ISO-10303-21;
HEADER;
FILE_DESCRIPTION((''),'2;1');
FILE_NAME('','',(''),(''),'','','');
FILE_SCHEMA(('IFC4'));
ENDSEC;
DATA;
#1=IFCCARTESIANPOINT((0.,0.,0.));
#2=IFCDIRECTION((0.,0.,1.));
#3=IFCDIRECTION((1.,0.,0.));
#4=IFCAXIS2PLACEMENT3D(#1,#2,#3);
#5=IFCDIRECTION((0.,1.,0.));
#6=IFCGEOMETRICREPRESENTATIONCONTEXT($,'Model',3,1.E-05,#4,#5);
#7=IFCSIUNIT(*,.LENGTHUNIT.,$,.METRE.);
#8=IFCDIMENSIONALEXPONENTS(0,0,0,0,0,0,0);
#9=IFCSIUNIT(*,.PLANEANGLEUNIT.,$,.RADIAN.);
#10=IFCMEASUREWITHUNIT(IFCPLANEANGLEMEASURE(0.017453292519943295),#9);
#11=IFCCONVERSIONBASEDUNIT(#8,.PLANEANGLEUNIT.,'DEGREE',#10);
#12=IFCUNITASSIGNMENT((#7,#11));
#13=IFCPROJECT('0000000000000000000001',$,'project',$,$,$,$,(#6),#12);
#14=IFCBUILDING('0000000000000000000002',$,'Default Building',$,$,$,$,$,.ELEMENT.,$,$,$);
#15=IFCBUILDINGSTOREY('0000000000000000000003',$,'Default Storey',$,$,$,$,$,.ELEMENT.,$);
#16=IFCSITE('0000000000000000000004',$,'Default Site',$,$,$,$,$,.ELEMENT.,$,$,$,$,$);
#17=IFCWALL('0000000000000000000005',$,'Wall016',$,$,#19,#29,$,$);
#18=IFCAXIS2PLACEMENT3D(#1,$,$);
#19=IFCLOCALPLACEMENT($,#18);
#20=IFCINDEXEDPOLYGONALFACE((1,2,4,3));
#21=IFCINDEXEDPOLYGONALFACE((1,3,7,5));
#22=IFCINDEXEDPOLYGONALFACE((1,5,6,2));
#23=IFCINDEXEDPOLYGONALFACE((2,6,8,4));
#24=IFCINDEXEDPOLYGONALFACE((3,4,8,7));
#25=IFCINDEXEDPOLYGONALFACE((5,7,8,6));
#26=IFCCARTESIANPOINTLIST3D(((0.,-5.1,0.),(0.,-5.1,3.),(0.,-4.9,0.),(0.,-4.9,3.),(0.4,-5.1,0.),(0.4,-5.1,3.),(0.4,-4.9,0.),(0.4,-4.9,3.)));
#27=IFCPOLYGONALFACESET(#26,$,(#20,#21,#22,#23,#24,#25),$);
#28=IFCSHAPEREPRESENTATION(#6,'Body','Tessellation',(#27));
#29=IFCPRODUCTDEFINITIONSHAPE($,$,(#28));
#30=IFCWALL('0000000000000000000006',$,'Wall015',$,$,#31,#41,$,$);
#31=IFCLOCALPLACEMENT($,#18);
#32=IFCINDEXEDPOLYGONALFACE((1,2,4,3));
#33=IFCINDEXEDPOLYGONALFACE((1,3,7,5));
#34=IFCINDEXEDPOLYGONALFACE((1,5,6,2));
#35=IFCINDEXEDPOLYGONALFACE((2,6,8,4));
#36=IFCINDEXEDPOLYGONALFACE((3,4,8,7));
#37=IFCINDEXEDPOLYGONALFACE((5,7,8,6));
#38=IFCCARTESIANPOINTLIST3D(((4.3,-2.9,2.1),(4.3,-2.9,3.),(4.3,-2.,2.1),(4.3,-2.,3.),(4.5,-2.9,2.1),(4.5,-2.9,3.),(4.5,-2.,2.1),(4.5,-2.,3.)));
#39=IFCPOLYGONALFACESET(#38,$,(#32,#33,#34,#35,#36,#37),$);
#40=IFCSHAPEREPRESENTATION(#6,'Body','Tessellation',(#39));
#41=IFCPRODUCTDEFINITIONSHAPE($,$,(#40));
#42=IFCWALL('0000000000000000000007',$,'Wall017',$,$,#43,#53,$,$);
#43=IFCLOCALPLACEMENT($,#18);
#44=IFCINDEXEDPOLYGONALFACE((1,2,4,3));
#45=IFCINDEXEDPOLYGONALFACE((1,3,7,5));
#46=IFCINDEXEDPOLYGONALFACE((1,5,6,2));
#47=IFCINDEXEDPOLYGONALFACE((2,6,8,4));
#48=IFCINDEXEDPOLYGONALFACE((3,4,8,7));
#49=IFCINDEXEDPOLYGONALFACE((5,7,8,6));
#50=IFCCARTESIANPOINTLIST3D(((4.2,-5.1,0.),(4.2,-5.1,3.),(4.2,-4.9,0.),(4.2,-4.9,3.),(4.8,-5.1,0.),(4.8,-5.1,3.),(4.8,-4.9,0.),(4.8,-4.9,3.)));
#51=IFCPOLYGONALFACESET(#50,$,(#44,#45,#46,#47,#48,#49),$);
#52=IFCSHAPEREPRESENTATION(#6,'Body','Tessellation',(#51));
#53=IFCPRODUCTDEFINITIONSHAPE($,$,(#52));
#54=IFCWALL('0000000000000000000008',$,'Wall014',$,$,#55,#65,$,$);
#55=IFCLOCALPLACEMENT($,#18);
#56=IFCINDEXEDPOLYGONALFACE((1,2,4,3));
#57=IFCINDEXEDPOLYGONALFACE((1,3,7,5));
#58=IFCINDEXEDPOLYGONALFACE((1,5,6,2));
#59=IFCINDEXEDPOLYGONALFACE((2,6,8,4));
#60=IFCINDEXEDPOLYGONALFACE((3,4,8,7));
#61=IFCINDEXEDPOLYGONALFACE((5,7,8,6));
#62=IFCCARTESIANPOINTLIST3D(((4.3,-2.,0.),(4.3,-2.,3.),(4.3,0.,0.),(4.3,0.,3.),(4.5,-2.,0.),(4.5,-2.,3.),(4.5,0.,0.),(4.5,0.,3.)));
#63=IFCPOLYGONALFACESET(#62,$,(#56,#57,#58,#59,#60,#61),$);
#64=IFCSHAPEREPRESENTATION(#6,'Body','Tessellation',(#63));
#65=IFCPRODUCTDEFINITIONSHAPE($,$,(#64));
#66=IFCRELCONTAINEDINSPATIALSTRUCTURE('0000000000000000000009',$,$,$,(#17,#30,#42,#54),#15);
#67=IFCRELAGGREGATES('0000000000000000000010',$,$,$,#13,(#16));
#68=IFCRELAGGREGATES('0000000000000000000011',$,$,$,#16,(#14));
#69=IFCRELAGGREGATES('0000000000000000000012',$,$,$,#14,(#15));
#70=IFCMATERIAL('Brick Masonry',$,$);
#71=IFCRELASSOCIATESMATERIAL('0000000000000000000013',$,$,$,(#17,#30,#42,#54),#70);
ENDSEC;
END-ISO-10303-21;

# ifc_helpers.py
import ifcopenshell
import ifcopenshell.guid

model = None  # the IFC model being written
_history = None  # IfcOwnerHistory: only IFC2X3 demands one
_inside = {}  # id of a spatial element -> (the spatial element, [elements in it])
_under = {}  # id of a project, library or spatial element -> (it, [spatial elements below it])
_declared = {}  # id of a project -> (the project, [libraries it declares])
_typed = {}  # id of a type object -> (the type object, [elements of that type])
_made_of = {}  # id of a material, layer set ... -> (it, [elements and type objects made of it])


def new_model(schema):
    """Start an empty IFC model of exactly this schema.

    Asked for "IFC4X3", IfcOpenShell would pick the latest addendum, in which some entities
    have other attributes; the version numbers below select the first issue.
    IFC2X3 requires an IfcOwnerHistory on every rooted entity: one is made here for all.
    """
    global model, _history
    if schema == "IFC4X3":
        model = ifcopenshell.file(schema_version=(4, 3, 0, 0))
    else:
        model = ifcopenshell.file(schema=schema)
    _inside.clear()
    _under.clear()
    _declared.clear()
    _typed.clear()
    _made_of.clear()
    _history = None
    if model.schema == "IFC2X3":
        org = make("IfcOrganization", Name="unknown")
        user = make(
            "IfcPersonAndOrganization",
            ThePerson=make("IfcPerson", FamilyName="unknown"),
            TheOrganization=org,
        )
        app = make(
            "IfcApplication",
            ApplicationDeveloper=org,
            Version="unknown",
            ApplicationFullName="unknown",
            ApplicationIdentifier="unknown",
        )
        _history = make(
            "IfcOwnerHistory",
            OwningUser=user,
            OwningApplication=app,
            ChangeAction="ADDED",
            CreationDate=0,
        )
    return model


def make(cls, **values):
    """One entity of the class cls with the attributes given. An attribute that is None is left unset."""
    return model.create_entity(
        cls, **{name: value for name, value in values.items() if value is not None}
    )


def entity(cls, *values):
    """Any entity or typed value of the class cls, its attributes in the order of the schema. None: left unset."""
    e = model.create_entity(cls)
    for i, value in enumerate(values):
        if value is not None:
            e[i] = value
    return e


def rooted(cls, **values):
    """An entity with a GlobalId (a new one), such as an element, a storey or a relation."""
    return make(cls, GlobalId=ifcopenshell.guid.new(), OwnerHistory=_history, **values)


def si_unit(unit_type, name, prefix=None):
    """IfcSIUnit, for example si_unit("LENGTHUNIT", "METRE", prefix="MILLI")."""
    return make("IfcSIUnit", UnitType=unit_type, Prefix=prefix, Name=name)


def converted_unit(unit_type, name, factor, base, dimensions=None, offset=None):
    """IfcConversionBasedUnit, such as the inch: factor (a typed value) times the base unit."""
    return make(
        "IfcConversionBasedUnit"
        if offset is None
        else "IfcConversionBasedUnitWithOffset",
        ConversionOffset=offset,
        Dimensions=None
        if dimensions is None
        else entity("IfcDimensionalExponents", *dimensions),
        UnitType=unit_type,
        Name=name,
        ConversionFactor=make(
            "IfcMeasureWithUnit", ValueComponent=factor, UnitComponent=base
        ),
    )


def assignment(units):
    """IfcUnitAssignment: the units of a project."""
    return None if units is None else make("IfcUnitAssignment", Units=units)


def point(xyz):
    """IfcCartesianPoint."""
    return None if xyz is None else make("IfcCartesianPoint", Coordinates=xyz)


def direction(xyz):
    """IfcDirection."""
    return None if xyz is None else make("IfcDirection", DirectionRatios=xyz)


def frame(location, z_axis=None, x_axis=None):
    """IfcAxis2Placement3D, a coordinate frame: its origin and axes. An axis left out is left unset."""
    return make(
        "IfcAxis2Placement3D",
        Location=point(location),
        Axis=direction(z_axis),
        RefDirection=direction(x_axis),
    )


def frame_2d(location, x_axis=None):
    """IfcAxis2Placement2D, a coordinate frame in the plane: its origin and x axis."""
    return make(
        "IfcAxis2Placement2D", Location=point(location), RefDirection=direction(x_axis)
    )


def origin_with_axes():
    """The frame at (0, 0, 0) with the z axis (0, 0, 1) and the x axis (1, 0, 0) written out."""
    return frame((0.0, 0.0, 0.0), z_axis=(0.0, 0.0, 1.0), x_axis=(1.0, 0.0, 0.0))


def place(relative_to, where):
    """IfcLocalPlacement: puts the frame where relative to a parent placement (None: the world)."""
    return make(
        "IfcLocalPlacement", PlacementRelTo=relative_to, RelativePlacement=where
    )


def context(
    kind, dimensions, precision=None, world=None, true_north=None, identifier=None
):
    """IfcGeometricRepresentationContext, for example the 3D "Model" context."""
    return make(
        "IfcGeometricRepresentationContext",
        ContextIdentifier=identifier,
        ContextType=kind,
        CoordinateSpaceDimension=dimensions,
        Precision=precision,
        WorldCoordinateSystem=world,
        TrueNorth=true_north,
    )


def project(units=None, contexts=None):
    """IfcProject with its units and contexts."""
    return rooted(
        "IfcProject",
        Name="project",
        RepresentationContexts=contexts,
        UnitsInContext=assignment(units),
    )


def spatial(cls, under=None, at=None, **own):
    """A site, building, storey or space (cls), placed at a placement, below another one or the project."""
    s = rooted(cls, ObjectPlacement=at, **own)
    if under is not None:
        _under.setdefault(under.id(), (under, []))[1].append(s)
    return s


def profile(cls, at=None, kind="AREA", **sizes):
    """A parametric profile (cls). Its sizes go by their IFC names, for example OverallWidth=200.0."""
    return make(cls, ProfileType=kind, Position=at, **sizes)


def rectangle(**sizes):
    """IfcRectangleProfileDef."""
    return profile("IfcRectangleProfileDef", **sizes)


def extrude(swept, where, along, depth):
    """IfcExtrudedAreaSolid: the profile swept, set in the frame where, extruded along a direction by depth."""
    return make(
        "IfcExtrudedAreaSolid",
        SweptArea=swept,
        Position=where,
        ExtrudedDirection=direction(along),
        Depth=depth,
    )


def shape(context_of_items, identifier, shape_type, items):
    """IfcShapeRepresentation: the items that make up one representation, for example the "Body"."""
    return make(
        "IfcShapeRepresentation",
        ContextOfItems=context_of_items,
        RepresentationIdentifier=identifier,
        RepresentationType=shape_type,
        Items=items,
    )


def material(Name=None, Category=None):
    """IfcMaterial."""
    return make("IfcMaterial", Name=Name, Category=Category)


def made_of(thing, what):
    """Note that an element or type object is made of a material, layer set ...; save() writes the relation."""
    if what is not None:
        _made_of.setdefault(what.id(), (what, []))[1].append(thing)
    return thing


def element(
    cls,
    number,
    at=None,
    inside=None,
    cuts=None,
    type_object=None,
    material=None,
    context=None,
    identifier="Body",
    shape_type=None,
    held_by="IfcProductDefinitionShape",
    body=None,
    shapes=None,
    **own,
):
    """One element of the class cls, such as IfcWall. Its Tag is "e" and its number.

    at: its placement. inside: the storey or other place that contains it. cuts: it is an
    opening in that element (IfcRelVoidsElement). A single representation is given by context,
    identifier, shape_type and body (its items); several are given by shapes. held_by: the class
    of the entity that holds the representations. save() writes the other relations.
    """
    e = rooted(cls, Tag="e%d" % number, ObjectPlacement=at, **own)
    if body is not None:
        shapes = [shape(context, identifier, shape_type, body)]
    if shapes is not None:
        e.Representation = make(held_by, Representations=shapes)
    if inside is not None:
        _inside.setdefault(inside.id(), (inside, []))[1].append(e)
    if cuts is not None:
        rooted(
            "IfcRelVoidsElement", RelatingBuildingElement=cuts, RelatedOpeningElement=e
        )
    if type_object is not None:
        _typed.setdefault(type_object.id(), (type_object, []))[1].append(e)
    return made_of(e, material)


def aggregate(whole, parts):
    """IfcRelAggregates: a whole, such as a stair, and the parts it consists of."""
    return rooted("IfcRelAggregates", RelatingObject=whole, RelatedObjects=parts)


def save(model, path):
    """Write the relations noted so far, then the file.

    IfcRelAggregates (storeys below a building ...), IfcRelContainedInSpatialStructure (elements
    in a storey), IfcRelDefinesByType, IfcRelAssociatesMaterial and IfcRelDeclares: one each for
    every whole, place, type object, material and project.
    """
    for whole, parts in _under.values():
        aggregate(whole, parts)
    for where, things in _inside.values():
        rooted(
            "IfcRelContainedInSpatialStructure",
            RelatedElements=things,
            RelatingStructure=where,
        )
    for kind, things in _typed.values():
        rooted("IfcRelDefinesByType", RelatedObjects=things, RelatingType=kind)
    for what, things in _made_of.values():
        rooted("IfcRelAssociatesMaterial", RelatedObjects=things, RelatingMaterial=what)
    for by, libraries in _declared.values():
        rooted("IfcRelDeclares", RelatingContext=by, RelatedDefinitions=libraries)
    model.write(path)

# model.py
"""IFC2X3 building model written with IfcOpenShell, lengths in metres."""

from ifc_helpers import new_model, entity, si_unit, converted_unit, direction, frame, frame_2d, origin_with_axes, place, context, project, spatial, rectangle, extrude, material, element, save


model = new_model("IFC2X3")

# Units and contexts
model_context = context("Model", 3, precision=1e-05, world=origin_with_axes(), true_north=direction((0.0, 1.0, 0.0)))
ifc_project = project(units=[si_unit("LENGTHUNIT", "METRE"), converted_unit("PLANEANGLEUNIT", "DEGREE", entity("IfcPlaneAngleMeasure", 0.017453292519943295), si_unit("PLANEANGLEUNIT", "RADIAN"), dimensions=[0, 0, 0, 0, 0, 0, 0])], contexts=[model_context])

# Site, building, storey
site = spatial("IfcSite", under=ifc_project, Name="Default Site", CompositionType="ELEMENT")
building = spatial("IfcBuilding", under=site, Name="Default Building", CompositionType="ELEMENT")
storey = spatial("IfcBuildingStorey", under=building, Name="Default Storey", CompositionType="ELEMENT")

# Shared definitions
placement = place(None, origin_with_axes())

# Walls
ifc_material_1 = material(Name="Brick Masonry")
element("IfcWall", 1, at=placement, inside=storey, material=ifc_material_1, Name="Wall016", context=model_context, shape_type="SweptSolid", body=[
    extrude(rectangle(XDim=0.4, YDim=0.2, at=frame_2d((0.0, 0.0), x_axis=(1.0, 0.0, 0.0))), frame((0.2, -5.0, 0.0), z_axis=(0.0, 0.0, 1.0), x_axis=(1.0, 0.0, 0.0)), (0.0, 0.0, 1.0), 3.0),
])
element("IfcWall", 2, at=placement, inside=storey, material=ifc_material_1, Name="Wall015", context=model_context, shape_type="SweptSolid", body=[
    extrude(rectangle(XDim=0.9, YDim=0.2, at=frame_2d((0.0, 0.0), x_axis=(0.0, -1.0, 0.0))), frame((4.4, -2.45, 2.1), z_axis=(0.0, 0.0, 1.0), x_axis=(1.0, 0.0, 0.0)), (0.0, 0.0, 1.0), 0.9),
])
element("IfcWall", 3, at=placement, inside=storey, material=ifc_material_1, Name="Wall017", context=model_context, shape_type="SweptSolid", body=[
    extrude(rectangle(XDim=0.6, YDim=0.2, at=frame_2d((0.0, 0.0), x_axis=(1.0, 0.0, 0.0))), frame((4.5, -5.0, 0.0), z_axis=(0.0, 0.0, 1.0), x_axis=(1.0, 0.0, 0.0)), (0.0, 0.0, 1.0), 3.0),
])
element("IfcWall", 4, at=placement, inside=storey, material=ifc_material_1, Name="Wall014", context=model_context, shape_type="SweptSolid", body=[
    extrude(rectangle(XDim=2.0, YDim=0.2, at=frame_2d((0.0, 0.0), x_axis=(0.0, -1.0, 0.0))), frame((4.4, -1.0, 0.0), z_axis=(0.0, 0.0, 1.0), x_axis=(1.0, 0.0, 0.0)), (0.0, 0.0, 1.0), 3.0),
])

save(model, "model.ifc")
